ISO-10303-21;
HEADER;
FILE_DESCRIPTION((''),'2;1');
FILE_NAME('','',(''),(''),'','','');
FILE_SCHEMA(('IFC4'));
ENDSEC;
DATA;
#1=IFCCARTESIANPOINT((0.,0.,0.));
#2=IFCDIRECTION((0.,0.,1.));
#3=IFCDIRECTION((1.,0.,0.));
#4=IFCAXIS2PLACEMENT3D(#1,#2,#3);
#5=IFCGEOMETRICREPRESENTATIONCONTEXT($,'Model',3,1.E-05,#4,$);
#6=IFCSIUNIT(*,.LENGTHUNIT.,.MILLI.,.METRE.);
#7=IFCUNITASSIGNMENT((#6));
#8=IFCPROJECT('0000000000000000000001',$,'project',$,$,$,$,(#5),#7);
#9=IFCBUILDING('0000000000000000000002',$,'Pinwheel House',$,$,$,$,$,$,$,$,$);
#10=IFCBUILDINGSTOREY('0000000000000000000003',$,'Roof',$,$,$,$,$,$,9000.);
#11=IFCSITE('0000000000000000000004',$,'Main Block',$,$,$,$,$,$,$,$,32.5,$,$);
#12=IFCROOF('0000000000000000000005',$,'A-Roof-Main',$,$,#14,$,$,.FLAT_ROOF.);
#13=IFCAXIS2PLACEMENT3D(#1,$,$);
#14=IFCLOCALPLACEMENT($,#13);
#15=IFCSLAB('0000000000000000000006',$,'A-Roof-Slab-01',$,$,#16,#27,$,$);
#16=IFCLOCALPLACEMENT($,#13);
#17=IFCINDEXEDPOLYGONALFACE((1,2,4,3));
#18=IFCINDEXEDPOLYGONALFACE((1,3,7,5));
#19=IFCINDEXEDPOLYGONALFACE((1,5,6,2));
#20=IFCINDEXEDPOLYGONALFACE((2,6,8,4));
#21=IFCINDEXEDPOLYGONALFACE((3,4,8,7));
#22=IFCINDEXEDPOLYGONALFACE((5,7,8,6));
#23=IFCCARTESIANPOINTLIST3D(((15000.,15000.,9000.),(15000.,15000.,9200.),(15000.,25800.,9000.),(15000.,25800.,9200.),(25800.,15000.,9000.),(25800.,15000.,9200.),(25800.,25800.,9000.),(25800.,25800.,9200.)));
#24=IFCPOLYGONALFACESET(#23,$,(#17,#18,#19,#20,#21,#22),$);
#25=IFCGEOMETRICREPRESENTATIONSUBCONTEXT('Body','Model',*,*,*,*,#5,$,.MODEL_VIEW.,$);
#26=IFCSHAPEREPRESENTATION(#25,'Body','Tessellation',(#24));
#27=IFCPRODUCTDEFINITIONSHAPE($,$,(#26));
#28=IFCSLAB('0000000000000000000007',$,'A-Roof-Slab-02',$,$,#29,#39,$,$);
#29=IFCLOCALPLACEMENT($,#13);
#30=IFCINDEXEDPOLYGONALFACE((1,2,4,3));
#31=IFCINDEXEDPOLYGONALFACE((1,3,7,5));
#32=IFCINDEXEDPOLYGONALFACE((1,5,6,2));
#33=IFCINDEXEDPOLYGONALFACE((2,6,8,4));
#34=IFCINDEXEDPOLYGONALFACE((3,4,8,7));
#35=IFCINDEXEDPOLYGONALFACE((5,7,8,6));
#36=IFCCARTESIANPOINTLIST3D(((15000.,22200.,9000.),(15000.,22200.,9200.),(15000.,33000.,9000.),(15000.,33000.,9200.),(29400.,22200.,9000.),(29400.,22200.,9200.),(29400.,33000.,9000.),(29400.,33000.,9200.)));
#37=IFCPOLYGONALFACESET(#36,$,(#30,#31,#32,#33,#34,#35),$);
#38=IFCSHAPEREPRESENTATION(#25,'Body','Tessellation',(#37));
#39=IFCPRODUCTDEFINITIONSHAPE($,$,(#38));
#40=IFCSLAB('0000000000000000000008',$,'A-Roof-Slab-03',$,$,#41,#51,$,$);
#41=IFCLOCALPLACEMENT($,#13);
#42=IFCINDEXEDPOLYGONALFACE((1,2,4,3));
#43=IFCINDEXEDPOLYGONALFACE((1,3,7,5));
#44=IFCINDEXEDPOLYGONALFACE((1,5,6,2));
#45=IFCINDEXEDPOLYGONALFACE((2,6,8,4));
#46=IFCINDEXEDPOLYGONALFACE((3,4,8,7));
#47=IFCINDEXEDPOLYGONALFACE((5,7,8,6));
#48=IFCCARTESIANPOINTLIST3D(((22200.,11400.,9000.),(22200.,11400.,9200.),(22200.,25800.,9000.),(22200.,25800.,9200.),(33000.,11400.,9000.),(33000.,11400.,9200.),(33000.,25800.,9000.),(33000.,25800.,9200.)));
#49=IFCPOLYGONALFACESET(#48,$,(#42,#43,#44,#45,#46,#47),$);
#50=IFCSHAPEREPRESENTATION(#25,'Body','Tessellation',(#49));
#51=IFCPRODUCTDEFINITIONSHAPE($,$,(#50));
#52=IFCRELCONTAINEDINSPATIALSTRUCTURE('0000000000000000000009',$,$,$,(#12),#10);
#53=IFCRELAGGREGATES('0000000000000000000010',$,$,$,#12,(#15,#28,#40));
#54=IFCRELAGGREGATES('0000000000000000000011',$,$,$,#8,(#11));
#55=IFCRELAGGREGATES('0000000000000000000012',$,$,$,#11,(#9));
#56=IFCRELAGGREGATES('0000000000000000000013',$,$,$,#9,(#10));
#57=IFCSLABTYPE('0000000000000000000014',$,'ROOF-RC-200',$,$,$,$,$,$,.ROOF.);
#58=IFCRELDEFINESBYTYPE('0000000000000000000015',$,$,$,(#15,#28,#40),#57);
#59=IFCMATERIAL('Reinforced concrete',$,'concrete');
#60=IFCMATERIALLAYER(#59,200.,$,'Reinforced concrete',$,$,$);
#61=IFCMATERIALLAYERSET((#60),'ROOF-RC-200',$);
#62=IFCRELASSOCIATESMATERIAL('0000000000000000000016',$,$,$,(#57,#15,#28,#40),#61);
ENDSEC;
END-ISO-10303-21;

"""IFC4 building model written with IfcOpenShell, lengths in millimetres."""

from ifc_helpers import new_model, si_unit, frame, origin_with_axes, place, context, subcontext, project, spatial, indexed_curve, outline, extrude, material, layer, layer_set, layer_usage, type_object, element, aggregate, save


model = new_model("IFC4")

# Units and contexts
model_context = context("Model", 3, precision=1e-05, world=origin_with_axes())
body_context = subcontext(model_context, "Body", "Model", "MODEL_VIEW")
ifc_project = project(units=[si_unit("LENGTHUNIT", "METRE", prefix="MILLI")], contexts=[model_context])

# Site, building, storey
site = spatial("IfcSite", under=ifc_project, Name="Main Block", RefElevation=32.5)
building = spatial("IfcBuilding", under=site, Name="Pinwheel House")
storey = spatial("IfcBuildingStorey", under=building, Name="Roof", Elevation=9000.0)

# Roof, slabs
roof = element("IfcRoof", 1, inside=storey, Name="A-Roof-Main", PredefinedType="FLAT_ROOF")
ifc_material = material(Name="Reinforced concrete", Category="concrete")
ifc_layer = layer(ifc_material, 200.0, Name="Reinforced concrete")
ifc_layer_set = layer_set([ifc_layer], Name="ROOF-RC-200")
ifc_layer_usage_1 = layer_usage(ifc_layer_set, "AXIS3", "POSITIVE", 0.0)
slab_type = type_object("IfcSlabType", Name="ROOF-RC-200", PredefinedType="ROOF", material=ifc_layer_set)
slab_1_placement = place(None, frame((0.0, 0.0, 9000.0), z_axis=(0.0, 0.0, 1.0), x_axis=(1.0, 0.0, 0.0)))
slab_1 = element("IfcSlab", 2, at=slab_1_placement, type_object=slab_type, material=ifc_layer_usage_1, Name="A-Roof-Slab-01", context=body_context, shape_type="SweptSolid", body=[
    extrude(outline(indexed_curve([(15000.0, 15000.0), (25800.0, 15000.0), (25800.0, 25800.0), (15000.0, 25800.0)])), None, (0.0, 0.0, 1.0), 200.0),
])
ifc_layer_usage_2 = layer_usage(ifc_layer_set, "AXIS3", "POSITIVE", 0.0)
slab_2_placement = place(None, frame((0.0, 0.0, 9000.0), z_axis=(0.0, 0.0, 1.0), x_axis=(1.0, 0.0, 0.0)))
slab_2 = element("IfcSlab", 3, at=slab_2_placement, type_object=slab_type, material=ifc_layer_usage_2, Name="A-Roof-Slab-02", context=body_context, shape_type="SweptSolid", body=[
    extrude(outline(indexed_curve([(15000.0, 22200.0), (29400.0, 22200.0), (29400.0, 33000.0), (15000.0, 33000.0)])), None, (0.0, 0.0, 1.0), 200.0),
])
ifc_layer_usage_3 = layer_usage(ifc_layer_set, "AXIS3", "POSITIVE", 0.0)
slab_3_placement = place(None, frame((0.0, 0.0, 9000.0), z_axis=(0.0, 0.0, 1.0), x_axis=(1.0, 0.0, 0.0)))
slab_3 = element("IfcSlab", 4, at=slab_3_placement, type_object=slab_type, material=ifc_layer_usage_3, Name="A-Roof-Slab-03", context=body_context, shape_type="SweptSolid", body=[
    extrude(outline(indexed_curve([(22200.0, 11400.0), (33000.0, 11400.0), (33000.0, 25800.0), (22200.0, 25800.0)])), None, (0.0, 0.0, 1.0), 200.0),
])
aggregate(roof, [slab_1, slab_2, slab_3])

save(model, "model.ifc")
